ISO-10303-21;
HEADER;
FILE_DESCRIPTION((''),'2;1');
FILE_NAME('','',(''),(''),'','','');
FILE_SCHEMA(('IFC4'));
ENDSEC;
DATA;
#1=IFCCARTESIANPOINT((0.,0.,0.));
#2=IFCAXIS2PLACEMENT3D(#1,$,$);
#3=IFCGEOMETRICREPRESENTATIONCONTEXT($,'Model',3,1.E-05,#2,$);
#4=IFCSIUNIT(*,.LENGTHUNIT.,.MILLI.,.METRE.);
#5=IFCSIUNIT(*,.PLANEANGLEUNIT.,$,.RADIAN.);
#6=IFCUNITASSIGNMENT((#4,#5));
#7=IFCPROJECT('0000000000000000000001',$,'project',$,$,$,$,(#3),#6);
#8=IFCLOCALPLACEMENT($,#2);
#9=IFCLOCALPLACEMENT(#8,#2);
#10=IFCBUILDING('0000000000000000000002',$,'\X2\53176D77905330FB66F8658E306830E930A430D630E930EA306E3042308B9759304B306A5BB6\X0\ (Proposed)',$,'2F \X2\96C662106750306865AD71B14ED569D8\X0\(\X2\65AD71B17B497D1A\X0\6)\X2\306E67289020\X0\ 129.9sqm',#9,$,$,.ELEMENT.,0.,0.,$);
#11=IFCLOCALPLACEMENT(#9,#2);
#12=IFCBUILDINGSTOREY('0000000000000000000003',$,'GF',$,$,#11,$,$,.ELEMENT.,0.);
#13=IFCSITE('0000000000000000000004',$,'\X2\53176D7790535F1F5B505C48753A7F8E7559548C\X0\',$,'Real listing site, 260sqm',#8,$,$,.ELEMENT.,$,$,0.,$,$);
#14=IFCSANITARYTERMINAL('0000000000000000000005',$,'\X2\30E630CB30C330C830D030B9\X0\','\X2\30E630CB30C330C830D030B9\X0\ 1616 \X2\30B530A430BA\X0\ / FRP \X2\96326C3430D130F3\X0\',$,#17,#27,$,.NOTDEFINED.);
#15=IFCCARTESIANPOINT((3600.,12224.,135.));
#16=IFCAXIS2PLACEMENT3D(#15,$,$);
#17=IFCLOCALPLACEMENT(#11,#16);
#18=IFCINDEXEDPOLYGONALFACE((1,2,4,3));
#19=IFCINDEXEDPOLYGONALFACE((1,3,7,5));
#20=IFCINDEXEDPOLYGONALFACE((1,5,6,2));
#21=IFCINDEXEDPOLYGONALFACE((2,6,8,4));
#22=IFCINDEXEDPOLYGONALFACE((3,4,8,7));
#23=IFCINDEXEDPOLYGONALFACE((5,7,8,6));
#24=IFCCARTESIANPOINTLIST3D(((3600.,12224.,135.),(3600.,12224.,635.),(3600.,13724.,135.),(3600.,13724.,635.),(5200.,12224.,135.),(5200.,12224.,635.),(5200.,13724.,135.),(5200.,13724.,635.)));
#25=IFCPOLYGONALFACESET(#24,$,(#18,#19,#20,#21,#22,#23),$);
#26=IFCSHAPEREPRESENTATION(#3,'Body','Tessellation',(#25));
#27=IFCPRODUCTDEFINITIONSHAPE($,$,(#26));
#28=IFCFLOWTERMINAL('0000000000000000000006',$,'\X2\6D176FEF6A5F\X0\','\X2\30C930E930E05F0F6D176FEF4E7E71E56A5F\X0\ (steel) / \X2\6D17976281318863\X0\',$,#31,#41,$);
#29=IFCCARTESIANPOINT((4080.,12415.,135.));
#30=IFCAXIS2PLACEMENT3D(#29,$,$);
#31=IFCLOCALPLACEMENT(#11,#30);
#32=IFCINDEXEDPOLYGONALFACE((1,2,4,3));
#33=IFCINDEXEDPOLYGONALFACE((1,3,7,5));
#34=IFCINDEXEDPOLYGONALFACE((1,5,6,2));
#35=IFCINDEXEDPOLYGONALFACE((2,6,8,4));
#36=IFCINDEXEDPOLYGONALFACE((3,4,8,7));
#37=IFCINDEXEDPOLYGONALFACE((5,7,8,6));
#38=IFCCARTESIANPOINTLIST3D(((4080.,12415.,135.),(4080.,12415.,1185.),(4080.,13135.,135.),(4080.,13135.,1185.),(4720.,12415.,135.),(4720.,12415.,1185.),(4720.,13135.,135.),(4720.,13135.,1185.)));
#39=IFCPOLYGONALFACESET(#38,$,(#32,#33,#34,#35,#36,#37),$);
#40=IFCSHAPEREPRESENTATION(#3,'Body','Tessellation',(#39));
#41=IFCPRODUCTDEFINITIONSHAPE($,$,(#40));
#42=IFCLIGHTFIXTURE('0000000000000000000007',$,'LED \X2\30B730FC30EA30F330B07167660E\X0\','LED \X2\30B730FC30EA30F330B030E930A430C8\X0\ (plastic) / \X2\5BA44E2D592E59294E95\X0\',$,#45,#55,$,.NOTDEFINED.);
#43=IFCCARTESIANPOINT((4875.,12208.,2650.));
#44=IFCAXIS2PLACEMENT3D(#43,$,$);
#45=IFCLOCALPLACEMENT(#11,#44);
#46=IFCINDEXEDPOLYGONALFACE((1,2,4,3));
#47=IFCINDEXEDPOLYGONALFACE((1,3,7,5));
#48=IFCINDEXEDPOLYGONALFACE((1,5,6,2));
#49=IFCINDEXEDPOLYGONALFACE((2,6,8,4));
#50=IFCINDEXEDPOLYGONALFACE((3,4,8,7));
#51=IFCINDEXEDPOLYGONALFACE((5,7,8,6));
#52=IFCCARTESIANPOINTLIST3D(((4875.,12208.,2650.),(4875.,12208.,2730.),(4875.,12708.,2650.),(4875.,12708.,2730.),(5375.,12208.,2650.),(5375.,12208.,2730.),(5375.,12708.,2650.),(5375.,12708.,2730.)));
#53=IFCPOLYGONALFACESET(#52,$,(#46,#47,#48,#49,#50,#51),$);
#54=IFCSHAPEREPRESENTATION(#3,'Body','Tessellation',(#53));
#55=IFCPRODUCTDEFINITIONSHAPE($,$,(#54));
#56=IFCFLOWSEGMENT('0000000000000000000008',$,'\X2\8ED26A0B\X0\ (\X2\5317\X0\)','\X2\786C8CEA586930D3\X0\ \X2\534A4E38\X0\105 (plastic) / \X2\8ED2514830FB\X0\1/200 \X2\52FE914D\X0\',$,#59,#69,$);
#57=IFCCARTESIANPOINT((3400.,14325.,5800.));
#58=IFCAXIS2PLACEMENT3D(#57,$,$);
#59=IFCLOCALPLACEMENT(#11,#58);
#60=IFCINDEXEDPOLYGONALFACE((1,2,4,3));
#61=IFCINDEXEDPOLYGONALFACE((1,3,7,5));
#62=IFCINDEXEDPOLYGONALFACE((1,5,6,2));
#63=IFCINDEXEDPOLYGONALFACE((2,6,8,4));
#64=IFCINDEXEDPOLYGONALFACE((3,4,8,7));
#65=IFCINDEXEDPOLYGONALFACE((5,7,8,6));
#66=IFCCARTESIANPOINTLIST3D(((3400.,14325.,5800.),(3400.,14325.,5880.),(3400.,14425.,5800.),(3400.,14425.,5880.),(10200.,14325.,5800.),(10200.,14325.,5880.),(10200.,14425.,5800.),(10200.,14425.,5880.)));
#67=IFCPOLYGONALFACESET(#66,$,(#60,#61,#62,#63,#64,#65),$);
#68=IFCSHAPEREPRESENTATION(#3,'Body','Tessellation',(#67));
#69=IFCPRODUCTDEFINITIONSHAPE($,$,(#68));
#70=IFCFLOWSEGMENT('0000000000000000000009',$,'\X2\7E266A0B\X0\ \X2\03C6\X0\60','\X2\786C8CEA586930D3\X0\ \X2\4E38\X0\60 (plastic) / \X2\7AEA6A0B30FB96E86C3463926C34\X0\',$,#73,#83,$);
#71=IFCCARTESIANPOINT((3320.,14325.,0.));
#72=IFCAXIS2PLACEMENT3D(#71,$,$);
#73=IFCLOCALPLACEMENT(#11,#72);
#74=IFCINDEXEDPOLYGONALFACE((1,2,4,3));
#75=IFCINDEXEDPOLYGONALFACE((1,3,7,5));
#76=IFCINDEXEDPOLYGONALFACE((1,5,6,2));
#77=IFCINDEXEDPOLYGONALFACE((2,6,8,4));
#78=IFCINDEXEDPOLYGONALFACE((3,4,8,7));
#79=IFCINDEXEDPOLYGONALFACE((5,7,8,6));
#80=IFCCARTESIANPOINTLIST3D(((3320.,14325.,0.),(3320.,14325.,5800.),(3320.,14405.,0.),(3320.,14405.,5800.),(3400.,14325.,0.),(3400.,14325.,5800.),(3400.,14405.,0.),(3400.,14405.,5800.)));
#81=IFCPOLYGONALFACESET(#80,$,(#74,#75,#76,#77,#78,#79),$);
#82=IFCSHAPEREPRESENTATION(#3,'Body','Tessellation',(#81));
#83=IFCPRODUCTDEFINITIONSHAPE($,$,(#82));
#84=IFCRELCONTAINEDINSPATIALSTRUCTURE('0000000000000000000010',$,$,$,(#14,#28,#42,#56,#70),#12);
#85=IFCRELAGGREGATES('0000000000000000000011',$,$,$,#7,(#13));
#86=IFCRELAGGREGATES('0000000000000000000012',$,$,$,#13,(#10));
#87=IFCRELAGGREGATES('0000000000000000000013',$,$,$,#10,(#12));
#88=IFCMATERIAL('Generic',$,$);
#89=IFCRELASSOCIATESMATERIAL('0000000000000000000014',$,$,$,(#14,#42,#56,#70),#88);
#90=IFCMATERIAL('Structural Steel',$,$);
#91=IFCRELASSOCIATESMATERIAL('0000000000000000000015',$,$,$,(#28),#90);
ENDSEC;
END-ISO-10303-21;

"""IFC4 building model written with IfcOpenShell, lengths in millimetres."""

from ifc_helpers import new_model, si_unit, frame, frame_2d, origin, place, context, project, spatial, rectangle, extrude, material, element, save


model = new_model("IFC4")

# Units and contexts
model_context = context("Model", 3, precision=1e-05, world=origin())
ifc_project = project(units=[si_unit("LENGTHUNIT", "METRE", prefix="MILLI"), si_unit("PLANEANGLEUNIT", "RADIAN")], contexts=[model_context])

# Site, building, storey
site_placement = place(None, origin())
site = spatial("IfcSite", under=ifc_project, at=site_placement, Name="北海道弟子屈町美留和", ObjectType="Real listing site, 260sqm", CompositionType="ELEMENT", RefElevation=0.0)
building_placement = place(site_placement, origin())
building = spatial("IfcBuilding", under=site, at=building_placement, Name="北海道・書斎とライブラリのある静かな家 (Proposed)", ObjectType="2F 集成材と断熱仕様(断熱等級6)の木造 129.9sqm", CompositionType="ELEMENT", ElevationOfRefHeight=0.0, ElevationOfTerrain=0.0)
storey_placement = place(building_placement, origin())
storey = spatial("IfcBuildingStorey", under=building, at=storey_placement, Name="GF", CompositionType="ELEMENT", Elevation=0.0)

# Sanitary terminal
ifc_material_1 = material(Name="Generic")
sanitary_terminal_placement = place(storey_placement, frame((3600.0, 12224.0, 135.0)))
element("IfcSanitaryTerminal", 1, at=sanitary_terminal_placement, inside=storey, material=ifc_material_1, Name="ユニットバス", Description="ユニットバス 1616 サイズ / FRP 防水パン", PredefinedType="NOTDEFINED", context=model_context, shape_type="SweptSolid", body=[
    extrude(rectangle(XDim=1600.0, YDim=1500.0, at=frame_2d((800.0, 750.0))), frame((3600.0, 12224.0, 135.0)), (0.0, 0.0, 1.0), 500.0),
])

# Flow terminal
ifc_material_2 = material(Name="Structural Steel")
flow_terminal_placement = place(storey_placement, frame((4080.0, 12415.0, 135.0)))
element("IfcFlowTerminal", 2, at=flow_terminal_placement, inside=storey, material=ifc_material_2, Name="洗濯機", Description="ドラム式洗濯乾燥機 (steel) / 洗面脱衣", context=model_context, shape_type="SweptSolid", body=[
    extrude(rectangle(XDim=640.0, YDim=720.0, at=frame_2d((320.0, 360.0))), frame((4080.0, 12415.0, 135.0)), (0.0, 0.0, 1.0), 1050.0),
])

# Light fixture
light_fixture_placement = place(storey_placement, frame((4875.0, 12208.0, 2650.0)))
element("IfcLightFixture", 3, at=light_fixture_placement, inside=storey, material=ifc_material_1, Name="LED シーリング照明", Description="LED シーリングライト (plastic) / 室中央天井", PredefinedType="NOTDEFINED", context=model_context, shape_type="SweptSolid", body=[
    extrude(rectangle(XDim=500.0, YDim=500.0, at=frame_2d((250.0, 250.0))), frame((4875.0, 12208.0, 2650.0)), (0.0, 0.0, 1.0), 80.0),
])

# Flow segments
flow_segment_1_placement = place(storey_placement, frame((3400.0, 14325.0, 5800.0)))
element("IfcFlowSegment", 4, at=flow_segment_1_placement, inside=storey, material=ifc_material_1, Name="軒樋 (北)", Description="硬質塩ビ 半丸105 (plastic) / 軒先・1/200 勾配", context=model_context, shape_type="SweptSolid", body=[
    extrude(rectangle(XDim=6800.0, YDim=100.0, at=frame_2d((3400.0, 50.0))), frame((3400.0, 14325.0, 5800.0)), (0.0, 0.0, 1.0), 80.0),
])
flow_segment_2_placement = place(storey_placement, frame((3320.0, 14325.0, 0.0)))
element("IfcFlowSegment", 5, at=flow_segment_2_placement, inside=storey, material=ifc_material_1, Name="縦樋 φ60", Description="硬質塩ビ 丸60 (plastic) / 竪樋・雨水排水", context=model_context, shape_type="SweptSolid", body=[
    extrude(rectangle(XDim=80.0, YDim=80.0, at=frame_2d((40.0, 40.0))), frame((3320.0, 14325.0, 0.0)), (0.0, 0.0, 1.0), 5800.0),
])

save(model, "model.ifc")
